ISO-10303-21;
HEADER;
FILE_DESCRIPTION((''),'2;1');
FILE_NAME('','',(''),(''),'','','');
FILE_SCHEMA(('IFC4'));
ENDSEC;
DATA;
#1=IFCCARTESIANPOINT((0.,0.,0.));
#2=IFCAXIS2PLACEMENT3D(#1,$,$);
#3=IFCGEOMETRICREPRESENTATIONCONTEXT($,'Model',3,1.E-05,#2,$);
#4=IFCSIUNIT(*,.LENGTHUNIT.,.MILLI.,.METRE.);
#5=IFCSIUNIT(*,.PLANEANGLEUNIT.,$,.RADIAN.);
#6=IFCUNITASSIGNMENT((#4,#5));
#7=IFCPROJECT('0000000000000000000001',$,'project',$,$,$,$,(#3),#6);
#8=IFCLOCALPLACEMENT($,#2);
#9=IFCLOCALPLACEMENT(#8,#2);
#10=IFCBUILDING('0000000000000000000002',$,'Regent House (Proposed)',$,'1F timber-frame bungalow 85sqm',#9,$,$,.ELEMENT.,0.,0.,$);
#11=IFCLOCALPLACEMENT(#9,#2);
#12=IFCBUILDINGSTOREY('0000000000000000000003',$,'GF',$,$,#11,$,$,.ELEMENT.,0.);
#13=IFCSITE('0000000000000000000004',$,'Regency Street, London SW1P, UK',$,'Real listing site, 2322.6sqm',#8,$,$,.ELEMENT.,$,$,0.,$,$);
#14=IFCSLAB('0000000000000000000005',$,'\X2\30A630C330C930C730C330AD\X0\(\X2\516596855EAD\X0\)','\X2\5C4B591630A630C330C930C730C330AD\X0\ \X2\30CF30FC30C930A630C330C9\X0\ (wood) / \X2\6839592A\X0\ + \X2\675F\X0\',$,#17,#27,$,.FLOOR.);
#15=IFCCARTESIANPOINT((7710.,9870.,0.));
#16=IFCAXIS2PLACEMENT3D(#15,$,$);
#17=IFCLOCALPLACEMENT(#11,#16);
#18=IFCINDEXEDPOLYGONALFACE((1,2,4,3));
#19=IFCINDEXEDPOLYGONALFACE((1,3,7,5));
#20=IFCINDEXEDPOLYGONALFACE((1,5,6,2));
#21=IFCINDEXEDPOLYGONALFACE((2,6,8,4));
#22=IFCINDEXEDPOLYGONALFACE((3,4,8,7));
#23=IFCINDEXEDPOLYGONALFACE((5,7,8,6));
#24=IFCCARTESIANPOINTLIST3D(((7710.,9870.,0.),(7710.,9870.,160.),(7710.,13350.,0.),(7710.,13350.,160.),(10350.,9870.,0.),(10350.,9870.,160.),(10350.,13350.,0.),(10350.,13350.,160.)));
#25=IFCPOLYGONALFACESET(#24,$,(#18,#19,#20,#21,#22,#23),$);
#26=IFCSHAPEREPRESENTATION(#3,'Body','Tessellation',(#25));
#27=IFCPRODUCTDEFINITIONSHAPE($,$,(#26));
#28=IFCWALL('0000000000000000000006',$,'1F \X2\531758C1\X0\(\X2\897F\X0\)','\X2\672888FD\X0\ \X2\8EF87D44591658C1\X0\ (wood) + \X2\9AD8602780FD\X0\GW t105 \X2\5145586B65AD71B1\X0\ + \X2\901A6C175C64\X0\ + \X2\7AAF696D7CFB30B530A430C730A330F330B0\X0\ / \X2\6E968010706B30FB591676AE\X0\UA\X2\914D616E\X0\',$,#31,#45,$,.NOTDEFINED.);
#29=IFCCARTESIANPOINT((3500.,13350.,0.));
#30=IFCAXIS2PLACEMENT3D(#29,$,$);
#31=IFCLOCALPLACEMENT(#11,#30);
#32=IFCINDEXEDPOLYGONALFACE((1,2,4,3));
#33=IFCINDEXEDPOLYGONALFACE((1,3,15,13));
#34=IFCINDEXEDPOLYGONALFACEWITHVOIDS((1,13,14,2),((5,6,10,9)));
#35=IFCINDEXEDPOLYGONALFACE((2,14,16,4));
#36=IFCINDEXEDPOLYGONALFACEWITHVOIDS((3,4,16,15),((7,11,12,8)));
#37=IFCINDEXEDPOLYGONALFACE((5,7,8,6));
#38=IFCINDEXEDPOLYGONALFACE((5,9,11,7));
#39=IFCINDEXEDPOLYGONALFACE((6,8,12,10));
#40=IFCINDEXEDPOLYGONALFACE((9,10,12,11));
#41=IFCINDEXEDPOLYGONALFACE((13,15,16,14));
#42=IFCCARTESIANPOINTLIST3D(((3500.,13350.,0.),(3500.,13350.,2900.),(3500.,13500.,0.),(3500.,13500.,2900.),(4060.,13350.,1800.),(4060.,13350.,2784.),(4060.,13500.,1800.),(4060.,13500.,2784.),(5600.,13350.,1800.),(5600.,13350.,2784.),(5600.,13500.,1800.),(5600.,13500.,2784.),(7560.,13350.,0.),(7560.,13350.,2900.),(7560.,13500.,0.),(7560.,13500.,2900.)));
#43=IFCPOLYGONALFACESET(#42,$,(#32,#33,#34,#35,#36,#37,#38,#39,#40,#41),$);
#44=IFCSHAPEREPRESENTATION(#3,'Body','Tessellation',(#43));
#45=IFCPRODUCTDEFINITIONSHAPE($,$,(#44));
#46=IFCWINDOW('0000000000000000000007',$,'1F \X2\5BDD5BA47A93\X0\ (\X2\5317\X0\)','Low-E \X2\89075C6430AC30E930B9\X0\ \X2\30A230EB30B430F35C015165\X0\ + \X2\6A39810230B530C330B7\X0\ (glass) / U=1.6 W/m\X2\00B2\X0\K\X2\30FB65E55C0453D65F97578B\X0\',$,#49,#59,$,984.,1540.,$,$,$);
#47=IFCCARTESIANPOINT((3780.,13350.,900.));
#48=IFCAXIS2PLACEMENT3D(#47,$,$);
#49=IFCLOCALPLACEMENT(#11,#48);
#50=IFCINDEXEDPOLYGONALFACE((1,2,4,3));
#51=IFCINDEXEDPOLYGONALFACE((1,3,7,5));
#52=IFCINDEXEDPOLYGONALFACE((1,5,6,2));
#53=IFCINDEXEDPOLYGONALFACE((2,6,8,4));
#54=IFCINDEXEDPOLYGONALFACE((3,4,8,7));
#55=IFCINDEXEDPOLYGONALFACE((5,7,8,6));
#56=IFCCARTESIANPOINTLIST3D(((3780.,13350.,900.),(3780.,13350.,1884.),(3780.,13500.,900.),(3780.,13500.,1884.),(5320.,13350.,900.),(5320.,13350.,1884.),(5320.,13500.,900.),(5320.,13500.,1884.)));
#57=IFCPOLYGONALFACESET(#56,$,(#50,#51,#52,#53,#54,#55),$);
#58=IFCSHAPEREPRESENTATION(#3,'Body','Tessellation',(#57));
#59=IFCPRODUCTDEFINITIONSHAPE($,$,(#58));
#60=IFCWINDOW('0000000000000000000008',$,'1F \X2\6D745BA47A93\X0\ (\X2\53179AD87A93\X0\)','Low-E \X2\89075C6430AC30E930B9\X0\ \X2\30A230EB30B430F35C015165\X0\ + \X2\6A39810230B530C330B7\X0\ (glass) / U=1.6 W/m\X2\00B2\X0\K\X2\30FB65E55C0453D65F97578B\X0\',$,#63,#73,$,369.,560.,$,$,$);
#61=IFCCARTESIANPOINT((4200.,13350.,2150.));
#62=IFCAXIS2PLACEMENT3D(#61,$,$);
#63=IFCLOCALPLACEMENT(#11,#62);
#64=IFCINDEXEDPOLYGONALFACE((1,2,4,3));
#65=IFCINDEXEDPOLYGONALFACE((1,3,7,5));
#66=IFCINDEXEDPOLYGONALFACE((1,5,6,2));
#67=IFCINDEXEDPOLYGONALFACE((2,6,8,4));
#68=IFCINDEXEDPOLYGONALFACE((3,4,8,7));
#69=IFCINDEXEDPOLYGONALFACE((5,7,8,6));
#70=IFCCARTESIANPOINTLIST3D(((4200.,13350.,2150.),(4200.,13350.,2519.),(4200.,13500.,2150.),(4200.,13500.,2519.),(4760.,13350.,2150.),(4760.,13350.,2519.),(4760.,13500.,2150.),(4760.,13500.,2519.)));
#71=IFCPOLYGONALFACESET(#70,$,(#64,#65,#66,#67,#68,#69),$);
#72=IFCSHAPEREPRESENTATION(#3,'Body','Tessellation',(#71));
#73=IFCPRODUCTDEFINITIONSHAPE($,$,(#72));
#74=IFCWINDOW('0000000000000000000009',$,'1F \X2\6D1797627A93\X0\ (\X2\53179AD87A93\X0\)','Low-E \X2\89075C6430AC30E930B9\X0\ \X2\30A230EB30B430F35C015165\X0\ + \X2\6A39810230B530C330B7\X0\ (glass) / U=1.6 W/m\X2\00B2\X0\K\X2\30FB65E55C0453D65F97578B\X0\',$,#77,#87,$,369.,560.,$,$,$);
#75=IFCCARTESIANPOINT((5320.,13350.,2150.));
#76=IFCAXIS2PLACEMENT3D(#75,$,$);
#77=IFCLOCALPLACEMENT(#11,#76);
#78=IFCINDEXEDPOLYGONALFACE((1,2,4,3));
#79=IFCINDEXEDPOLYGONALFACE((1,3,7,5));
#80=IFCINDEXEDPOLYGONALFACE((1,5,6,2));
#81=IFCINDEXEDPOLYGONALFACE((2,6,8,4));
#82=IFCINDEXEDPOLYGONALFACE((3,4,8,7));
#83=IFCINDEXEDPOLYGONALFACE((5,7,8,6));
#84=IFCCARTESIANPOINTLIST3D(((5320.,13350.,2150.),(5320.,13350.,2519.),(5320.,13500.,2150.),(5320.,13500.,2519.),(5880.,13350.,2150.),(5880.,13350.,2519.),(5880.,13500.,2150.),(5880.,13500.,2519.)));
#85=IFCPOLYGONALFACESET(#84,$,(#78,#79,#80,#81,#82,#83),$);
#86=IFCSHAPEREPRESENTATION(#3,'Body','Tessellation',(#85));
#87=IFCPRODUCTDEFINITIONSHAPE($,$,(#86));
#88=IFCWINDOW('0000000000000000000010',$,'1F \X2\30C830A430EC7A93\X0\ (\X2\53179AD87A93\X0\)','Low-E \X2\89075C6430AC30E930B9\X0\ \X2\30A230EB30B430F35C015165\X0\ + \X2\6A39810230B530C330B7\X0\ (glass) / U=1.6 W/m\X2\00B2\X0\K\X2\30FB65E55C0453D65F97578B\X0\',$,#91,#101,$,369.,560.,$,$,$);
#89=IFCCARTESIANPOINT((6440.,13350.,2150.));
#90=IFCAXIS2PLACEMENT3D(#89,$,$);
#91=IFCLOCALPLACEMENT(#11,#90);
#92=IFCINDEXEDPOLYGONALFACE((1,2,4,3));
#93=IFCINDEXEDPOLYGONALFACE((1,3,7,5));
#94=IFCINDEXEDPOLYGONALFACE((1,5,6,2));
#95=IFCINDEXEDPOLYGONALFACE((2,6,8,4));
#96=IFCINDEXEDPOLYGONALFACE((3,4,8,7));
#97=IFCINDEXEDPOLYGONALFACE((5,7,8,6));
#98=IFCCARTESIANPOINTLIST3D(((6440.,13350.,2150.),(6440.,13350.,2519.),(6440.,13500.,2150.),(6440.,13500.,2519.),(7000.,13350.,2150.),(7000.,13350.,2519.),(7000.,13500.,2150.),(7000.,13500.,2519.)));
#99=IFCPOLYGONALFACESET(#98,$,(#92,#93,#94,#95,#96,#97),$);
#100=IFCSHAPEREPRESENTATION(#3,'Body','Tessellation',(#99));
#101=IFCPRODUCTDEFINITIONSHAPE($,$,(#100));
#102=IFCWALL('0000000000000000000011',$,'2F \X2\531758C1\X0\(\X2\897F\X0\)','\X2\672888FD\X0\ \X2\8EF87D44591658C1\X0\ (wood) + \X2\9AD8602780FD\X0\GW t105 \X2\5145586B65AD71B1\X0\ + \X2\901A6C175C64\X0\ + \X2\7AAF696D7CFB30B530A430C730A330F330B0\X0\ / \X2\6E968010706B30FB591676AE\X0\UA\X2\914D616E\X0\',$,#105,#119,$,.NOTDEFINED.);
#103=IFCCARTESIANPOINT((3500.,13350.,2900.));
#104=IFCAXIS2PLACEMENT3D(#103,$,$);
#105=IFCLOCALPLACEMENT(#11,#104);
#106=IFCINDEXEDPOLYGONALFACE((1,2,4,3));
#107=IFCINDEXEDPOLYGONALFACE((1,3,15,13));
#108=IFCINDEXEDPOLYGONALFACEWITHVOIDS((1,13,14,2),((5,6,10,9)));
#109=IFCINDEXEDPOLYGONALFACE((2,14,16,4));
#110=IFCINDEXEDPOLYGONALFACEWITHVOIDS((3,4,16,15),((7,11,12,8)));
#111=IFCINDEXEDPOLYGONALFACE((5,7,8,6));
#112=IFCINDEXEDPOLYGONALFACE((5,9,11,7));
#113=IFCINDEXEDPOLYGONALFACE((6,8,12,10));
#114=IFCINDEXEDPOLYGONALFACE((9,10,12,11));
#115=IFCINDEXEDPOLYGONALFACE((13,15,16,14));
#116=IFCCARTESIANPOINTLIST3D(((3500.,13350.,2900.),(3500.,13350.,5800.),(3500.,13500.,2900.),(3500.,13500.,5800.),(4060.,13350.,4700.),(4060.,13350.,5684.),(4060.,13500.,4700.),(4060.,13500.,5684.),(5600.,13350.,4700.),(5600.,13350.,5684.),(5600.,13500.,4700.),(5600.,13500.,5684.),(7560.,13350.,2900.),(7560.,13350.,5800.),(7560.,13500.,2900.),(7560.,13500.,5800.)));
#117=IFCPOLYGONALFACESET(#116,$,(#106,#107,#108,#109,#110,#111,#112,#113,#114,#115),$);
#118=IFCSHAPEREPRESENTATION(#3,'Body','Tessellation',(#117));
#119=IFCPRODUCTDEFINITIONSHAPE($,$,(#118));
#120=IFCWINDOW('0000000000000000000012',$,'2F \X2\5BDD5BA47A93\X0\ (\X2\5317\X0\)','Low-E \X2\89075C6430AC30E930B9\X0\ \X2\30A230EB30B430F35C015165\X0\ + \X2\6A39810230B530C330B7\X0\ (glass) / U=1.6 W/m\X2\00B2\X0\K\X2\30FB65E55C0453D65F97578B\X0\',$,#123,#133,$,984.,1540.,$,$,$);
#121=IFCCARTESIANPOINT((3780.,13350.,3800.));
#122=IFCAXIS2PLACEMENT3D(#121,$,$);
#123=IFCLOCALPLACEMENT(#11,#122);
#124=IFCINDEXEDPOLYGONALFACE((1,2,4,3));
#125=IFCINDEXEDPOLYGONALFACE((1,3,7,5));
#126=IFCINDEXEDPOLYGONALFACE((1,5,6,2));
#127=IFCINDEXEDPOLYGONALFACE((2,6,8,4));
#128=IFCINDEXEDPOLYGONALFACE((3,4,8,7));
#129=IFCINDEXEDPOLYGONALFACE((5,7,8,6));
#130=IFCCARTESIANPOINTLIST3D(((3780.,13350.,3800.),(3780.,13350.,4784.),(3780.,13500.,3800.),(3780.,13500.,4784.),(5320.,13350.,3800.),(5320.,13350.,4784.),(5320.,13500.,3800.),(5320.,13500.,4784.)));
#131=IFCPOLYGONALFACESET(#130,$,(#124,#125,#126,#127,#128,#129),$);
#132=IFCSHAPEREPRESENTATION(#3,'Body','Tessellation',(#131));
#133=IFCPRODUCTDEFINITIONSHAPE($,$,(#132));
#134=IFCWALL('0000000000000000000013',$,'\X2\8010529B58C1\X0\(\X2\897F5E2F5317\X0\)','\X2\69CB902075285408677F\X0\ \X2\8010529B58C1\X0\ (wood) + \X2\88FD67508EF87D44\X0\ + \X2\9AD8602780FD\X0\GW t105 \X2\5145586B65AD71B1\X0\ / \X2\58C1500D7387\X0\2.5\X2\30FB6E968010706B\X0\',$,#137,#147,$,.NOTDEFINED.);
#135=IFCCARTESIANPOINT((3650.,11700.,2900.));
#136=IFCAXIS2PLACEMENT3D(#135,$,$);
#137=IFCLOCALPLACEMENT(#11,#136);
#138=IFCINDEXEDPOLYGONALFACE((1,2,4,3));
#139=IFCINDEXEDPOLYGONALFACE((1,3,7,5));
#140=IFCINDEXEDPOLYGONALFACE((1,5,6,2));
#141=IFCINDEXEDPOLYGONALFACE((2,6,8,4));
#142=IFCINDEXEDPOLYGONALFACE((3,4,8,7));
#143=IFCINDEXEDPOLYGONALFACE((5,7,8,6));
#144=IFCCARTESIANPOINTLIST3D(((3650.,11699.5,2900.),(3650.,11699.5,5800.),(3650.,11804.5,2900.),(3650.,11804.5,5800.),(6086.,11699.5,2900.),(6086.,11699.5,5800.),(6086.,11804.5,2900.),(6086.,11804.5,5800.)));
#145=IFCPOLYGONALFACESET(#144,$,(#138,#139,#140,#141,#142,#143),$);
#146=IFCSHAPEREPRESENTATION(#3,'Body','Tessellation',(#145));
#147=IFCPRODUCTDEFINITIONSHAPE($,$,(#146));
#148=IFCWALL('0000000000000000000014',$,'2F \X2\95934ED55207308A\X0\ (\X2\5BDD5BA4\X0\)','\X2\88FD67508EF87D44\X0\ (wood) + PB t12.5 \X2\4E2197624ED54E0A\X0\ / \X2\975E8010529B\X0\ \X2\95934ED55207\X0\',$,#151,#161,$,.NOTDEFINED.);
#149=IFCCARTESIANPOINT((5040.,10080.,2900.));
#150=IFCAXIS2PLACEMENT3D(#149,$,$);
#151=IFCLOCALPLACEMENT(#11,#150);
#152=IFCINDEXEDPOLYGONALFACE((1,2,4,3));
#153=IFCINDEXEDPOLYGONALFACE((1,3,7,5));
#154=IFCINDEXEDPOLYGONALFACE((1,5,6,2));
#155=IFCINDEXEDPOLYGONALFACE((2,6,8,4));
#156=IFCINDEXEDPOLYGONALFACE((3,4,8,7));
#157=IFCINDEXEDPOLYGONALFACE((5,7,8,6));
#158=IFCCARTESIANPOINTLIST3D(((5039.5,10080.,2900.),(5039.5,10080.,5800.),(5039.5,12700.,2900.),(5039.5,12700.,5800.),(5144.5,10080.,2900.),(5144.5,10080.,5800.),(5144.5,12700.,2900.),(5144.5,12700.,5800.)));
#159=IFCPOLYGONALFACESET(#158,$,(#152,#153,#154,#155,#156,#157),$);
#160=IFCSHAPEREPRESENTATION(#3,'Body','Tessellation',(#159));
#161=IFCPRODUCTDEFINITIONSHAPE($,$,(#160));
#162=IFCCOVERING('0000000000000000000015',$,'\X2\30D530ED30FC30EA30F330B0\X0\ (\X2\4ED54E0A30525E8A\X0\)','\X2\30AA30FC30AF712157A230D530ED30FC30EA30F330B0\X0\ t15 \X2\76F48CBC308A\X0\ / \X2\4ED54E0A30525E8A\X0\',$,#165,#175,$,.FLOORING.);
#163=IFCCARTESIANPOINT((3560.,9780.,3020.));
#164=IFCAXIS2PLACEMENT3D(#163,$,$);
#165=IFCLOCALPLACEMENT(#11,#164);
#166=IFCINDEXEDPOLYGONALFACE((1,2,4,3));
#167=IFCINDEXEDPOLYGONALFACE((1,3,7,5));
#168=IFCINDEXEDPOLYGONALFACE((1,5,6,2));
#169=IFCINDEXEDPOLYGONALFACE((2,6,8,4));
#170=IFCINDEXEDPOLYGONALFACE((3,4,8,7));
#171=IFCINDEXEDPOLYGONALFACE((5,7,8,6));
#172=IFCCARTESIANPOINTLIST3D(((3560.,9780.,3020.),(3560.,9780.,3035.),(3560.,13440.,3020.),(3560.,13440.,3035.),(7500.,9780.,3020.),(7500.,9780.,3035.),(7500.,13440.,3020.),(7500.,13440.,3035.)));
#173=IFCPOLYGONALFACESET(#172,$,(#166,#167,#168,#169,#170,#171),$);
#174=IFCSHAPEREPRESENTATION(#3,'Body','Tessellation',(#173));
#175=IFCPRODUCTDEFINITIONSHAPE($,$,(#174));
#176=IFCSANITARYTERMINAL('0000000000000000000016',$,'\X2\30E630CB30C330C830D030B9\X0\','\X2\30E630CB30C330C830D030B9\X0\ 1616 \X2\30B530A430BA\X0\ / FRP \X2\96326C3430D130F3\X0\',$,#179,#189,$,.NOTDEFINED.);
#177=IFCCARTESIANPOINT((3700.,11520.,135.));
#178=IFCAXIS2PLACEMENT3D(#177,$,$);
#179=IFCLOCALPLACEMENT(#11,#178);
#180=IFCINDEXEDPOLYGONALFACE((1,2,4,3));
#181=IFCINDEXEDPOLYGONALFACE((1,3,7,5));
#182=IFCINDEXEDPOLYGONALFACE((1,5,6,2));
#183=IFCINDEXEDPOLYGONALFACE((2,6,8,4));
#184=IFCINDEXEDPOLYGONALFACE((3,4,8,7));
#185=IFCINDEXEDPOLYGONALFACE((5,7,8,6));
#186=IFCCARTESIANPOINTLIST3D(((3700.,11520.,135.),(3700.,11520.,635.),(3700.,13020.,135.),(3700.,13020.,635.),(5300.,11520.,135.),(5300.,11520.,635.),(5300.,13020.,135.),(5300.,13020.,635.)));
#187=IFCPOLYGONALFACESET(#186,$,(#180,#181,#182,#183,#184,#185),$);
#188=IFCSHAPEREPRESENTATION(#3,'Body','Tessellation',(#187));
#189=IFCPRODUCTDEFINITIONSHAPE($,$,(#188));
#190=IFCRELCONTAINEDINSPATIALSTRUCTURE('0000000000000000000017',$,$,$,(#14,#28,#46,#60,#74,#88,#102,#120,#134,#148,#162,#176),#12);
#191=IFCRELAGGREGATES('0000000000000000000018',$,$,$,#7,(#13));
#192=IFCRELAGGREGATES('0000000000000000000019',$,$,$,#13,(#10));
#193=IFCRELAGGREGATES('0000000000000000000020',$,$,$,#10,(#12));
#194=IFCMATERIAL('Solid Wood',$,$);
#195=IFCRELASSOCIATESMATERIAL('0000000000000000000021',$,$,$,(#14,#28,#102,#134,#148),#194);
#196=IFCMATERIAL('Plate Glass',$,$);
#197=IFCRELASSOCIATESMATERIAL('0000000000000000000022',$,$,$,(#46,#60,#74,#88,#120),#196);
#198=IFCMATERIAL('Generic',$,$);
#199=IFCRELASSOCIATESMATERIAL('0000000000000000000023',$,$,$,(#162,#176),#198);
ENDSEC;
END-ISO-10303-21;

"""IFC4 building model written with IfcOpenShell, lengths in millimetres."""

from ifc_helpers import new_model, si_unit, frame, frame_2d, origin, place, context, project, spatial, rectangle, extrude, material, element, fill, save


model = new_model("IFC4")

# Units and contexts
model_context = context("Model", 3, precision=1e-05, world=origin())
ifc_project = project(units=[si_unit("LENGTHUNIT", "METRE", prefix="MILLI"), si_unit("PLANEANGLEUNIT", "RADIAN")], contexts=[model_context])

# Site, building, storey
site_placement = place(None, origin())
site = spatial("IfcSite", under=ifc_project, at=site_placement, Name="Regency Street, London SW1P, UK", ObjectType="Real listing site, 2322.6sqm", CompositionType="ELEMENT", RefElevation=0.0)
building_placement = place(site_placement, origin())
building = spatial("IfcBuilding", under=site, at=building_placement, Name="Regent House (Proposed)", ObjectType="1F timber-frame bungalow 85sqm", CompositionType="ELEMENT", ElevationOfRefHeight=0.0, ElevationOfTerrain=0.0)
storey_placement = place(building_placement, origin())
storey = spatial("IfcBuildingStorey", under=building, at=storey_placement, Name="GF", CompositionType="ELEMENT", Elevation=0.0)

# Slab
ifc_material_1 = material(Name="Solid Wood")
slab_placement = place(storey_placement, frame((7710.0, 9870.0, 0.0)))
element("IfcSlab", 1, at=slab_placement, inside=storey, material=ifc_material_1, Name="ウッドデッキ(入隅庭)", Description="屋外ウッドデッキ ハードウッド (wood) / 根太 + 束", PredefinedType="FLOOR", context=model_context, shape_type="SweptSolid", body=[
    extrude(rectangle(XDim=2640.0, YDim=3480.0, at=frame_2d((1320.0, 1740.0))), frame((7710.0, 9870.0, 0.0)), (0.0, 0.0, 1.0), 160.0),
])

# Wall, openings, windows
wall_1_placement = place(storey_placement, frame((3500.0, 13350.0, 0.0)))
wall_1 = element("IfcWall", 2, at=wall_1_placement, inside=storey, material=ifc_material_1, Name="1F 北壁(西)", Description="木製 軸組外壁 (wood) + 高性能GW t105 充填断熱 + 通気層 + 窯業系サイディング / 準耐火・外皮UA配慮", PredefinedType="NOTDEFINED", context=model_context, shape_type="SweptSolid", body=[
    extrude(rectangle(XDim=4060.0, YDim=150.0, at=frame_2d((2030.0, 75.0))), frame((3500.0, 13350.0, 0.0)), (0.0, 0.0, 1.0), 2900.0),
])
opening_1_placement = place(storey_placement, frame((3780.0, 13350.0, 900.0)))
opening_1 = element("IfcOpeningElement", 3, at=opening_1_placement, cuts=wall_1, PredefinedType="NOTDEFINED", context=model_context, shape_type="SweptSolid", body=[
    extrude(rectangle(XDim=1540.0, YDim=150.0, at=frame_2d((770.0, 75.0))), frame((3780.0, 13350.0, 900.0)), (0.0, 0.0, 1.0), 984.0),
])
opening_2_placement = place(storey_placement, frame((4200.0, 13350.0, 2150.0)))
opening_2 = element("IfcOpeningElement", 4, at=opening_2_placement, cuts=wall_1, PredefinedType="NOTDEFINED", context=model_context, shape_type="SweptSolid", body=[
    extrude(rectangle(XDim=560.0, YDim=150.0, at=frame_2d((280.0, 75.0))), frame((4200.0, 13350.0, 2150.0)), (0.0, 0.0, 1.0), 369.0),
])
opening_3_placement = place(storey_placement, frame((5320.0, 13350.0, 2150.0)))
opening_3 = element("IfcOpeningElement", 5, at=opening_3_placement, cuts=wall_1, PredefinedType="NOTDEFINED", context=model_context, shape_type="SweptSolid", body=[
    extrude(rectangle(XDim=560.0, YDim=150.0, at=frame_2d((280.0, 75.0))), frame((5320.0, 13350.0, 2150.0)), (0.0, 0.0, 1.0), 369.0),
])
opening_4_placement = place(storey_placement, frame((6440.0, 13350.0, 2150.0)))
opening_4 = element("IfcOpeningElement", 6, at=opening_4_placement, cuts=wall_1, PredefinedType="NOTDEFINED", context=model_context, shape_type="SweptSolid", body=[
    extrude(rectangle(XDim=560.0, YDim=150.0, at=frame_2d((280.0, 75.0))), frame((6440.0, 13350.0, 2150.0)), (0.0, 0.0, 1.0), 369.0),
])
ifc_material_2 = material(Name="Plate Glass")
window_1_placement = place(storey_placement, frame((3780.0, 13350.0, 900.0)))
window_1 = element("IfcWindow", 7, at=window_1_placement, inside=storey, material=ifc_material_2, Name="1F 寝室窓 (北)", Description="Low-E 複層ガラス アルゴン封入 + 樹脂サッシ (glass) / U=1.6 W/m²K・日射取得型", OverallHeight=984.0, OverallWidth=1540.0, context=model_context, shape_type="SweptSolid", body=[
    extrude(rectangle(XDim=1540.0, YDim=150.0, at=frame_2d((770.0, 75.0))), frame((3780.0, 13350.0, 900.0)), (0.0, 0.0, 1.0), 984.0),
])
fill(opening_1, window_1)
window_2_placement = place(storey_placement, frame((4200.0, 13350.0, 2150.0)))
window_2 = element("IfcWindow", 8, at=window_2_placement, inside=storey, material=ifc_material_2, Name="1F 浴室窓 (北高窓)", Description="Low-E 複層ガラス アルゴン封入 + 樹脂サッシ (glass) / U=1.6 W/m²K・日射取得型", OverallHeight=369.0, OverallWidth=560.0, context=model_context, shape_type="SweptSolid", body=[
    extrude(rectangle(XDim=560.0, YDim=150.0, at=frame_2d((280.0, 75.0))), frame((4200.0, 13350.0, 2150.0)), (0.0, 0.0, 1.0), 369.0),
])
fill(opening_2, window_2)
window_3_placement = place(storey_placement, frame((5320.0, 13350.0, 2150.0)))
window_3 = element("IfcWindow", 9, at=window_3_placement, inside=storey, material=ifc_material_2, Name="1F 洗面窓 (北高窓)", Description="Low-E 複層ガラス アルゴン封入 + 樹脂サッシ (glass) / U=1.6 W/m²K・日射取得型", OverallHeight=369.0, OverallWidth=560.0, context=model_context, shape_type="SweptSolid", body=[
    extrude(rectangle(XDim=560.0, YDim=150.0, at=frame_2d((280.0, 75.0))), frame((5320.0, 13350.0, 2150.0)), (0.0, 0.0, 1.0), 369.0),
])
fill(opening_3, window_3)
window_4_placement = place(storey_placement, frame((6440.0, 13350.0, 2150.0)))
window_4 = element("IfcWindow", 10, at=window_4_placement, inside=storey, material=ifc_material_2, Name="1F トイレ窓 (北高窓)", Description="Low-E 複層ガラス アルゴン封入 + 樹脂サッシ (glass) / U=1.6 W/m²K・日射取得型", OverallHeight=369.0, OverallWidth=560.0, context=model_context, shape_type="SweptSolid", body=[
    extrude(rectangle(XDim=560.0, YDim=150.0, at=frame_2d((280.0, 75.0))), frame((6440.0, 13350.0, 2150.0)), (0.0, 0.0, 1.0), 369.0),
])
fill(opening_4, window_4)

# Wall, opening, window
wall_2_placement = place(storey_placement, frame((3500.0, 13350.0, 2900.0)))
wall_2 = element("IfcWall", 11, at=wall_2_placement, inside=storey, material=ifc_material_1, Name="2F 北壁(西)", Description="木製 軸組外壁 (wood) + 高性能GW t105 充填断熱 + 通気層 + 窯業系サイディング / 準耐火・外皮UA配慮", PredefinedType="NOTDEFINED", context=model_context, shape_type="SweptSolid", body=[
    extrude(rectangle(XDim=4060.0, YDim=150.0, at=frame_2d((2030.0, 75.0))), frame((3500.0, 13350.0, 2900.0)), (0.0, 0.0, 1.0), 2900.0),
])
opening_5_placement = place(storey_placement, frame((3780.0, 13350.0, 3800.0)))
opening_5 = element("IfcOpeningElement", 12, at=opening_5_placement, cuts=wall_2, PredefinedType="NOTDEFINED", context=model_context, shape_type="SweptSolid", body=[
    extrude(rectangle(XDim=1540.0, YDim=150.0, at=frame_2d((770.0, 75.0))), frame((3780.0, 13350.0, 3800.0)), (0.0, 0.0, 1.0), 984.0),
])
window_5_placement = place(storey_placement, frame((3780.0, 13350.0, 3800.0)))
window_5 = element("IfcWindow", 13, at=window_5_placement, inside=storey, material=ifc_material_2, Name="2F 寝室窓 (北)", Description="Low-E 複層ガラス アルゴン封入 + 樹脂サッシ (glass) / U=1.6 W/m²K・日射取得型", OverallHeight=984.0, OverallWidth=1540.0, context=model_context, shape_type="SweptSolid", body=[
    extrude(rectangle(XDim=1540.0, YDim=150.0, at=frame_2d((770.0, 75.0))), frame((3780.0, 13350.0, 3800.0)), (0.0, 0.0, 1.0), 984.0),
])
fill(opening_5, window_5)

# Walls
wall_3_placement = place(storey_placement, frame((3650.0, 11700.0, 2900.0)))
element("IfcWall", 14, at=wall_3_placement, inside=storey, material=ifc_material_1, Name="耐力壁(西帯北)", Description="構造用合板 耐力壁 (wood) + 製材軸組 + 高性能GW t105 充填断熱 / 壁倍率2.5・準耐火", PredefinedType="NOTDEFINED", context=model_context, shape_type="SweptSolid", body=[
    extrude(rectangle(XDim=2436.0, YDim=105.0, at=frame_2d((1218.0, 52.0))), frame((3650.0, 11700.0, 2900.0)), (0.0, 0.0, 1.0), 2900.0),
])
wall_4_placement = place(storey_placement, frame((5040.0, 10080.0, 2900.0)))
element("IfcWall", 15, at=wall_4_placement, inside=storey, material=ifc_material_1, Name="2F 間仕切り (寝室)", Description="製材軸組 (wood) + PB t12.5 両面仕上 / 非耐力 間仕切", PredefinedType="NOTDEFINED", context=model_context, shape_type="SweptSolid", body=[
    extrude(rectangle(XDim=105.0, YDim=2620.0, at=frame_2d((52.0, 1310.0))), frame((5040.0, 10080.0, 2900.0)), (0.0, 0.0, 1.0), 2900.0),
])

# Covering
ifc_material_3 = material(Name="Generic")
covering_placement = place(storey_placement, frame((3560.0, 9780.0, 3020.0)))
element("IfcCovering", 16, at=covering_placement, inside=storey, material=ifc_material_3, Name="フローリング (仕上げ床)", Description="オーク無垢フローリング t15 直貼り / 仕上げ床", PredefinedType="FLOORING", context=model_context, shape_type="SweptSolid", body=[
    extrude(rectangle(XDim=3940.0, YDim=3660.0, at=frame_2d((1970.0, 1830.0))), frame((3560.0, 9780.0, 3020.0)), (0.0, 0.0, 1.0), 15.0),
])

# Sanitary terminal
sanitary_terminal_1_placement = place(storey_placement, frame((3700.0, 11520.0, 135.0)))
element("IfcSanitaryTerminal", 17, at=sanitary_terminal_1_placement, inside=storey, material=ifc_material_3, Name="ユニットバス", Description="ユニットバス 1616 サイズ / FRP 防水パン", PredefinedType="NOTDEFINED", context=model_context, shape_type="SweptSolid", body=[
    extrude(rectangle(XDim=1600.0, YDim=1500.0, at=frame_2d((800.0, 750.0))), frame((3700.0, 11520.0, 135.0)), (0.0, 0.0, 1.0), 500.0),
])

save(model, "model.ifc")
